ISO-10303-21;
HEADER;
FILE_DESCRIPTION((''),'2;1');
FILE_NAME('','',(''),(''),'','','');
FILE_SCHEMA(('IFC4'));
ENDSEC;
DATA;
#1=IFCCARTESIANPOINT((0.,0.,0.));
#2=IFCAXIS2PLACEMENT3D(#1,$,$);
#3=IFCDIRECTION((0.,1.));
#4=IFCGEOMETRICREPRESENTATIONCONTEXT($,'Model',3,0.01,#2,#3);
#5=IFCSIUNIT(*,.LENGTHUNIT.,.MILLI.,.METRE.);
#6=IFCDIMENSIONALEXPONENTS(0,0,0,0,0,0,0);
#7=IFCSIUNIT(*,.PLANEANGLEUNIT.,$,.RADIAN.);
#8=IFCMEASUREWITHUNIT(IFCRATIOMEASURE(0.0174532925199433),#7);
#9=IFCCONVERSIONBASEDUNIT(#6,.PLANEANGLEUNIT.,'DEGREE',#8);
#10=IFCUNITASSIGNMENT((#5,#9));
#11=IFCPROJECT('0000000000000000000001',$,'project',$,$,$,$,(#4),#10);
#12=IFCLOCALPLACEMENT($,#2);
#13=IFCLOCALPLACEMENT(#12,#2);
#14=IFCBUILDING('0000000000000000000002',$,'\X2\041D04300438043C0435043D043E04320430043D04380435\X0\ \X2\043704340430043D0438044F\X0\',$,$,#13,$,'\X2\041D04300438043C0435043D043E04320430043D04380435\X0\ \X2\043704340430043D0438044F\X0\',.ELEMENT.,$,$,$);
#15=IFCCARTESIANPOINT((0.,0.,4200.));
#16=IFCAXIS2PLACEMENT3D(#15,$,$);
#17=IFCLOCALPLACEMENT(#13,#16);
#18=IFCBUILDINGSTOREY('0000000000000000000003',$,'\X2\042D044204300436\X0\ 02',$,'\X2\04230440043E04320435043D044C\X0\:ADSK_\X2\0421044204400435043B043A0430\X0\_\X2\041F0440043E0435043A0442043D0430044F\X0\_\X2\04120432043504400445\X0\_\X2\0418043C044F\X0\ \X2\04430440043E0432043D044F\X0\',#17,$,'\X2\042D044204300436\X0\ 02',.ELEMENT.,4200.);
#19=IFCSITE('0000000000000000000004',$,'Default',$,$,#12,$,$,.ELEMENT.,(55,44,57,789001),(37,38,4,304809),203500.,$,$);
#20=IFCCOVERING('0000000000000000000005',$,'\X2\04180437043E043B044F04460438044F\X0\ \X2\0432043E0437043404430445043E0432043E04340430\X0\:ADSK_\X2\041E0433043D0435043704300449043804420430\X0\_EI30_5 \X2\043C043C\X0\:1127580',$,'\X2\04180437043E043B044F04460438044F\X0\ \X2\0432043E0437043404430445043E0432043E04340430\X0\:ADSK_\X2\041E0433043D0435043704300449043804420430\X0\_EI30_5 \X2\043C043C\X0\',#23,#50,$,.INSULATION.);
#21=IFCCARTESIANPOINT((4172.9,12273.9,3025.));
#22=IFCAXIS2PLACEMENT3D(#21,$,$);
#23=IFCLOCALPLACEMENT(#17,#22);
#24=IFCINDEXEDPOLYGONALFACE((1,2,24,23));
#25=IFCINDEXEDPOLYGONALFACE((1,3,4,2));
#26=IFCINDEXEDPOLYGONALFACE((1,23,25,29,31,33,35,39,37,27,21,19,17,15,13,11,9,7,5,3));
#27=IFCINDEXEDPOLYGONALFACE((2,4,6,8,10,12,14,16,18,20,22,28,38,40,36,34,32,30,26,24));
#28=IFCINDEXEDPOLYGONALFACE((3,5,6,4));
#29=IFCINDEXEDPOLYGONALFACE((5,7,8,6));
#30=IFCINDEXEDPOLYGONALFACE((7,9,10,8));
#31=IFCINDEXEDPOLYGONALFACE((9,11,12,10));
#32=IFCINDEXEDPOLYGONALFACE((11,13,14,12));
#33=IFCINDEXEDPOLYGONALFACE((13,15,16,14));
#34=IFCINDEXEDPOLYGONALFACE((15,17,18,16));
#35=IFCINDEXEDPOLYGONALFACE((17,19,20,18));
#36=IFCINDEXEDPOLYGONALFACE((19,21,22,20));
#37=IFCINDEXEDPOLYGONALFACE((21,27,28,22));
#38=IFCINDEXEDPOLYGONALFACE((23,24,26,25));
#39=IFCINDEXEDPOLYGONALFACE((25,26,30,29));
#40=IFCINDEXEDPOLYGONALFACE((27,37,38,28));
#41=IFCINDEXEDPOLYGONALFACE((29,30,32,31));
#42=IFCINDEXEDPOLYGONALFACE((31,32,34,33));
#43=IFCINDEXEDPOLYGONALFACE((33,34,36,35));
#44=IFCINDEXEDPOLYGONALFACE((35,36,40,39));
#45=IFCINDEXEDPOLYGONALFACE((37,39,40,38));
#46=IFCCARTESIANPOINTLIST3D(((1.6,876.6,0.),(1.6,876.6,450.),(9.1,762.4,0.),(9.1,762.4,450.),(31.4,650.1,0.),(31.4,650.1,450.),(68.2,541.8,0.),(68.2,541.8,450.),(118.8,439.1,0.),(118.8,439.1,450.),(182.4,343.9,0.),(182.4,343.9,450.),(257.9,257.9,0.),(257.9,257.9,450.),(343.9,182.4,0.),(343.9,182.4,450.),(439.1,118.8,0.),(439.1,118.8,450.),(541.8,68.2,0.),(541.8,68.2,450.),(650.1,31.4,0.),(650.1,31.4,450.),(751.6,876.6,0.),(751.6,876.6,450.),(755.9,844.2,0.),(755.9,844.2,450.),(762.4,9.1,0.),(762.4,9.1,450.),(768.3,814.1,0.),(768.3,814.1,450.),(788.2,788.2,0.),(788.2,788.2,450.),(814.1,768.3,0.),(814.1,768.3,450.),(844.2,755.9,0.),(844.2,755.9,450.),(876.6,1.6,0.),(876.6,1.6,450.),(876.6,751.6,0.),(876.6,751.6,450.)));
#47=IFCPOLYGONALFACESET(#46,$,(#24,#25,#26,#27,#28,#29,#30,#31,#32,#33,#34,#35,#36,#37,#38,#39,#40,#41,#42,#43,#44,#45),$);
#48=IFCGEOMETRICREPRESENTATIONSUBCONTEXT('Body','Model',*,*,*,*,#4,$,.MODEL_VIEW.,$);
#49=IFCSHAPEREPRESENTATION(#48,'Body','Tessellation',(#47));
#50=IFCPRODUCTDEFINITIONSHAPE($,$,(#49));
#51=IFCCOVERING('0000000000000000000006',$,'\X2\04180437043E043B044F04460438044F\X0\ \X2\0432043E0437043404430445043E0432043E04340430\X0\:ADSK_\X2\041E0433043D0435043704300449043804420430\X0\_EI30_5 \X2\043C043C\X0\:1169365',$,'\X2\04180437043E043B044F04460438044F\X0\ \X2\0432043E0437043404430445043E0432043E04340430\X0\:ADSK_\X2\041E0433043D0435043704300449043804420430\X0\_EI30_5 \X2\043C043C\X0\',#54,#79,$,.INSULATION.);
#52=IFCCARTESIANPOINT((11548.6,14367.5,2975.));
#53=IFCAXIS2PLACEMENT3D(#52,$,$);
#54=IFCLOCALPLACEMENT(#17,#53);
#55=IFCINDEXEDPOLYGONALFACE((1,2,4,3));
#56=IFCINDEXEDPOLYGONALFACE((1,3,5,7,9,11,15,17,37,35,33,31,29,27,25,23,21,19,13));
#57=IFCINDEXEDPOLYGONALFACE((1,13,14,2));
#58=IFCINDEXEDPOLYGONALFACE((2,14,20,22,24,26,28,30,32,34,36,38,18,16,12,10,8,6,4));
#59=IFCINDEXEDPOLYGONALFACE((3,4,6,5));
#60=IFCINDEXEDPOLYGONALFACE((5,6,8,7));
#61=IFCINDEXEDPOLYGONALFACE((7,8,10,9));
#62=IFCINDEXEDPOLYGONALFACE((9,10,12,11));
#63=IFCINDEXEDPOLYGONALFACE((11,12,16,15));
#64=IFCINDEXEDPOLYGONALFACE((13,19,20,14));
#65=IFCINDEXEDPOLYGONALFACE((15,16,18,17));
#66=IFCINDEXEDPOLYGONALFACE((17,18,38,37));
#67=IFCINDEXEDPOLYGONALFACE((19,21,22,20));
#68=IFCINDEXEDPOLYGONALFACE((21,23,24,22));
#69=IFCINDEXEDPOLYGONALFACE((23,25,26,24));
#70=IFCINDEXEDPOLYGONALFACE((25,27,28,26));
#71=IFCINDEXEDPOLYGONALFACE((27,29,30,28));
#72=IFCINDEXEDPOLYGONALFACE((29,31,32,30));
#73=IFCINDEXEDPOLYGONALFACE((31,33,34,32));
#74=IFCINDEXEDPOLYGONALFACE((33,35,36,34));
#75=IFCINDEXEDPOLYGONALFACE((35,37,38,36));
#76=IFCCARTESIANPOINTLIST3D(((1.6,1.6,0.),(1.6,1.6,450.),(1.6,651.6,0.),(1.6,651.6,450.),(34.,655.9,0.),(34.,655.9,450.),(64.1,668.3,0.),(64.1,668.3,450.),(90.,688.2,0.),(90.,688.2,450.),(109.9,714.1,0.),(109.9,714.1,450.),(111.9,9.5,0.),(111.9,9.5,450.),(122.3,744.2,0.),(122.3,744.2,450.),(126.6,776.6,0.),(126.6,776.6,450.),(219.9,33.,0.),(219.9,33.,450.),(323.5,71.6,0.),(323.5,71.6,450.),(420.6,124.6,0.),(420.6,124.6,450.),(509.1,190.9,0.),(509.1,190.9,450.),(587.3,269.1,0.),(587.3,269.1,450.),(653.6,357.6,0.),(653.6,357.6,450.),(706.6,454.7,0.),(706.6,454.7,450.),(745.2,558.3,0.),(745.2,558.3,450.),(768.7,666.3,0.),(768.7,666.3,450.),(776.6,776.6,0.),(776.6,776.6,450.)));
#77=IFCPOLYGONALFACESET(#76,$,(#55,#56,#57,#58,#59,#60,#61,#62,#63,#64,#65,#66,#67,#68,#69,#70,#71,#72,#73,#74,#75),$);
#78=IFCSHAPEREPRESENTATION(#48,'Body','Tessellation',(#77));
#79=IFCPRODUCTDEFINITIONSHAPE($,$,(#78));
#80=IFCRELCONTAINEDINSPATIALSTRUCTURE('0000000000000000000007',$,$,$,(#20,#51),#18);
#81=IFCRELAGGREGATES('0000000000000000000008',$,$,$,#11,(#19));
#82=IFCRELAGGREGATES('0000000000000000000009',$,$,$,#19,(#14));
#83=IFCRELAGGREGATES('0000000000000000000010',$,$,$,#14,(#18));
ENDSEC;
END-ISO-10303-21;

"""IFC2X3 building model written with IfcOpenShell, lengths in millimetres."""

from ifc_helpers import new_model, entity, si_unit, converted_unit, direction, frame, frame_2d, origin, place, context, subcontext, project, spatial, polyline, circle_curve, parameter, trimmed, segment, composite_curve, outline, extrude, element, save


model = new_model("IFC2X3")

# Units and contexts
model_context = context("Model", 3, precision=0.01, world=origin(), true_north=direction((0.0, 1.0)))
body_context = subcontext(model_context, "Body", "Model", "MODEL_VIEW")
ifc_project = project(units=[si_unit("LENGTHUNIT", "METRE", prefix="MILLI"), converted_unit("PLANEANGLEUNIT", "DEGREE", entity("IfcRatioMeasure", 0.0174532925199433), si_unit("PLANEANGLEUNIT", "RADIAN"), dimensions=[0, 0, 0, 0, 0, 0, 0])], contexts=[model_context])

# Site, building, storey
site_placement = place(None, origin())
site = spatial("IfcSite", under=ifc_project, at=site_placement, Name="Default", CompositionType="ELEMENT", RefLatitude=(55, 44, 57, 789001), RefLongitude=(37, 38, 4, 304809), RefElevation=203500.0)
building_placement = place(site_placement, origin())
building = spatial("IfcBuilding", under=site, at=building_placement, Name="Наименование здания", LongName="Наименование здания", CompositionType="ELEMENT")
storey_placement = place(building_placement, frame((0.0, 0.0, 4200.0)))
storey = spatial("IfcBuildingStorey", under=building, at=storey_placement, Name="Этаж 02", ObjectType="Уровень:ADSK_Стрелка_Проектная_Вверх_Имя уровня", LongName="Этаж 02", CompositionType="ELEMENT", Elevation=4200.0)

# Coverings
covering_1_placement = place(storey_placement, frame((4172.9, 12273.9, 3025.0)))
element("IfcCovering", 1, at=covering_1_placement, inside=storey, Name="Изоляция воздуховода:ADSK_Огнезащита_EI30_5 мм:1127580", ObjectType="Изоляция воздуховода:ADSK_Огнезащита_EI30_5 мм", PredefinedType="INSULATION", context=body_context, shape_type="SweptSolid", body=[
    extrude(outline(composite_curve([segment(polyline([(-250.0, 125.0), (-250.0, -625.0)]), True, "CONTINUOUS"), segment(trimmed(circle_curve(frame_2d((-250.0, 250.0), x_axis=(1.0, 0.0)), 875.0), [parameter(270.0)], [parameter(0.0)], True, "PARAMETER"), True, "CONTINUOUS"), segment(polyline([(625.0, 250.0), (-125.0, 250.0)]), True, "CONTINUOUS"), segment(trimmed(circle_curve(frame_2d((-250.0, 250.0), x_axis=(1.0, 0.0)), 125.0), [parameter(270.0)], [parameter(360.0)], True, "PARAMETER"), False, "CONTINUOUS")], self_intersect=False)), frame((626.6, 626.6, 0.0), z_axis=(0.0, 0.0, -1.0), x_axis=(-1.0, 0.0, 0.0)), (0.0, 0.0, -1.0), 450.0),
])
covering_2_placement = place(storey_placement, frame((11548.6, 14367.5, 2975.0)))
element("IfcCovering", 2, at=covering_2_placement, inside=storey, Name="Изоляция воздуховода:ADSK_Огнезащита_EI30_5 мм:1169365", ObjectType="Изоляция воздуховода:ADSK_Огнезащита_EI30_5 мм", PredefinedType="INSULATION", context=body_context, shape_type="SweptSolid", body=[
    extrude(outline(composite_curve([segment(polyline([(-225.0, 100.0), (-225.0, -550.0)]), True, "CONTINUOUS"), segment(trimmed(circle_curve(frame_2d((-225.0, 225.0), x_axis=(1.0, 0.0)), 775.0), [parameter(270.0)], [parameter(0.0)], True, "PARAMETER"), True, "CONTINUOUS"), segment(polyline([(550.0, 225.0), (-100.0, 225.0)]), True, "CONTINUOUS"), segment(trimmed(circle_curve(frame_2d((-225.0, 225.0), x_axis=(1.0, 0.0)), 125.0), [parameter(270.0)], [parameter(360.0)], True, "PARAMETER"), False, "CONTINUOUS")], self_intersect=False)), frame((226.6, 551.6, 0.0), z_axis=(0.0, 0.0, -1.0), x_axis=(0.0, -1.0, 0.0)), (0.0, 0.0, -1.0), 450.0),
])

save(model, "model.ifc")
